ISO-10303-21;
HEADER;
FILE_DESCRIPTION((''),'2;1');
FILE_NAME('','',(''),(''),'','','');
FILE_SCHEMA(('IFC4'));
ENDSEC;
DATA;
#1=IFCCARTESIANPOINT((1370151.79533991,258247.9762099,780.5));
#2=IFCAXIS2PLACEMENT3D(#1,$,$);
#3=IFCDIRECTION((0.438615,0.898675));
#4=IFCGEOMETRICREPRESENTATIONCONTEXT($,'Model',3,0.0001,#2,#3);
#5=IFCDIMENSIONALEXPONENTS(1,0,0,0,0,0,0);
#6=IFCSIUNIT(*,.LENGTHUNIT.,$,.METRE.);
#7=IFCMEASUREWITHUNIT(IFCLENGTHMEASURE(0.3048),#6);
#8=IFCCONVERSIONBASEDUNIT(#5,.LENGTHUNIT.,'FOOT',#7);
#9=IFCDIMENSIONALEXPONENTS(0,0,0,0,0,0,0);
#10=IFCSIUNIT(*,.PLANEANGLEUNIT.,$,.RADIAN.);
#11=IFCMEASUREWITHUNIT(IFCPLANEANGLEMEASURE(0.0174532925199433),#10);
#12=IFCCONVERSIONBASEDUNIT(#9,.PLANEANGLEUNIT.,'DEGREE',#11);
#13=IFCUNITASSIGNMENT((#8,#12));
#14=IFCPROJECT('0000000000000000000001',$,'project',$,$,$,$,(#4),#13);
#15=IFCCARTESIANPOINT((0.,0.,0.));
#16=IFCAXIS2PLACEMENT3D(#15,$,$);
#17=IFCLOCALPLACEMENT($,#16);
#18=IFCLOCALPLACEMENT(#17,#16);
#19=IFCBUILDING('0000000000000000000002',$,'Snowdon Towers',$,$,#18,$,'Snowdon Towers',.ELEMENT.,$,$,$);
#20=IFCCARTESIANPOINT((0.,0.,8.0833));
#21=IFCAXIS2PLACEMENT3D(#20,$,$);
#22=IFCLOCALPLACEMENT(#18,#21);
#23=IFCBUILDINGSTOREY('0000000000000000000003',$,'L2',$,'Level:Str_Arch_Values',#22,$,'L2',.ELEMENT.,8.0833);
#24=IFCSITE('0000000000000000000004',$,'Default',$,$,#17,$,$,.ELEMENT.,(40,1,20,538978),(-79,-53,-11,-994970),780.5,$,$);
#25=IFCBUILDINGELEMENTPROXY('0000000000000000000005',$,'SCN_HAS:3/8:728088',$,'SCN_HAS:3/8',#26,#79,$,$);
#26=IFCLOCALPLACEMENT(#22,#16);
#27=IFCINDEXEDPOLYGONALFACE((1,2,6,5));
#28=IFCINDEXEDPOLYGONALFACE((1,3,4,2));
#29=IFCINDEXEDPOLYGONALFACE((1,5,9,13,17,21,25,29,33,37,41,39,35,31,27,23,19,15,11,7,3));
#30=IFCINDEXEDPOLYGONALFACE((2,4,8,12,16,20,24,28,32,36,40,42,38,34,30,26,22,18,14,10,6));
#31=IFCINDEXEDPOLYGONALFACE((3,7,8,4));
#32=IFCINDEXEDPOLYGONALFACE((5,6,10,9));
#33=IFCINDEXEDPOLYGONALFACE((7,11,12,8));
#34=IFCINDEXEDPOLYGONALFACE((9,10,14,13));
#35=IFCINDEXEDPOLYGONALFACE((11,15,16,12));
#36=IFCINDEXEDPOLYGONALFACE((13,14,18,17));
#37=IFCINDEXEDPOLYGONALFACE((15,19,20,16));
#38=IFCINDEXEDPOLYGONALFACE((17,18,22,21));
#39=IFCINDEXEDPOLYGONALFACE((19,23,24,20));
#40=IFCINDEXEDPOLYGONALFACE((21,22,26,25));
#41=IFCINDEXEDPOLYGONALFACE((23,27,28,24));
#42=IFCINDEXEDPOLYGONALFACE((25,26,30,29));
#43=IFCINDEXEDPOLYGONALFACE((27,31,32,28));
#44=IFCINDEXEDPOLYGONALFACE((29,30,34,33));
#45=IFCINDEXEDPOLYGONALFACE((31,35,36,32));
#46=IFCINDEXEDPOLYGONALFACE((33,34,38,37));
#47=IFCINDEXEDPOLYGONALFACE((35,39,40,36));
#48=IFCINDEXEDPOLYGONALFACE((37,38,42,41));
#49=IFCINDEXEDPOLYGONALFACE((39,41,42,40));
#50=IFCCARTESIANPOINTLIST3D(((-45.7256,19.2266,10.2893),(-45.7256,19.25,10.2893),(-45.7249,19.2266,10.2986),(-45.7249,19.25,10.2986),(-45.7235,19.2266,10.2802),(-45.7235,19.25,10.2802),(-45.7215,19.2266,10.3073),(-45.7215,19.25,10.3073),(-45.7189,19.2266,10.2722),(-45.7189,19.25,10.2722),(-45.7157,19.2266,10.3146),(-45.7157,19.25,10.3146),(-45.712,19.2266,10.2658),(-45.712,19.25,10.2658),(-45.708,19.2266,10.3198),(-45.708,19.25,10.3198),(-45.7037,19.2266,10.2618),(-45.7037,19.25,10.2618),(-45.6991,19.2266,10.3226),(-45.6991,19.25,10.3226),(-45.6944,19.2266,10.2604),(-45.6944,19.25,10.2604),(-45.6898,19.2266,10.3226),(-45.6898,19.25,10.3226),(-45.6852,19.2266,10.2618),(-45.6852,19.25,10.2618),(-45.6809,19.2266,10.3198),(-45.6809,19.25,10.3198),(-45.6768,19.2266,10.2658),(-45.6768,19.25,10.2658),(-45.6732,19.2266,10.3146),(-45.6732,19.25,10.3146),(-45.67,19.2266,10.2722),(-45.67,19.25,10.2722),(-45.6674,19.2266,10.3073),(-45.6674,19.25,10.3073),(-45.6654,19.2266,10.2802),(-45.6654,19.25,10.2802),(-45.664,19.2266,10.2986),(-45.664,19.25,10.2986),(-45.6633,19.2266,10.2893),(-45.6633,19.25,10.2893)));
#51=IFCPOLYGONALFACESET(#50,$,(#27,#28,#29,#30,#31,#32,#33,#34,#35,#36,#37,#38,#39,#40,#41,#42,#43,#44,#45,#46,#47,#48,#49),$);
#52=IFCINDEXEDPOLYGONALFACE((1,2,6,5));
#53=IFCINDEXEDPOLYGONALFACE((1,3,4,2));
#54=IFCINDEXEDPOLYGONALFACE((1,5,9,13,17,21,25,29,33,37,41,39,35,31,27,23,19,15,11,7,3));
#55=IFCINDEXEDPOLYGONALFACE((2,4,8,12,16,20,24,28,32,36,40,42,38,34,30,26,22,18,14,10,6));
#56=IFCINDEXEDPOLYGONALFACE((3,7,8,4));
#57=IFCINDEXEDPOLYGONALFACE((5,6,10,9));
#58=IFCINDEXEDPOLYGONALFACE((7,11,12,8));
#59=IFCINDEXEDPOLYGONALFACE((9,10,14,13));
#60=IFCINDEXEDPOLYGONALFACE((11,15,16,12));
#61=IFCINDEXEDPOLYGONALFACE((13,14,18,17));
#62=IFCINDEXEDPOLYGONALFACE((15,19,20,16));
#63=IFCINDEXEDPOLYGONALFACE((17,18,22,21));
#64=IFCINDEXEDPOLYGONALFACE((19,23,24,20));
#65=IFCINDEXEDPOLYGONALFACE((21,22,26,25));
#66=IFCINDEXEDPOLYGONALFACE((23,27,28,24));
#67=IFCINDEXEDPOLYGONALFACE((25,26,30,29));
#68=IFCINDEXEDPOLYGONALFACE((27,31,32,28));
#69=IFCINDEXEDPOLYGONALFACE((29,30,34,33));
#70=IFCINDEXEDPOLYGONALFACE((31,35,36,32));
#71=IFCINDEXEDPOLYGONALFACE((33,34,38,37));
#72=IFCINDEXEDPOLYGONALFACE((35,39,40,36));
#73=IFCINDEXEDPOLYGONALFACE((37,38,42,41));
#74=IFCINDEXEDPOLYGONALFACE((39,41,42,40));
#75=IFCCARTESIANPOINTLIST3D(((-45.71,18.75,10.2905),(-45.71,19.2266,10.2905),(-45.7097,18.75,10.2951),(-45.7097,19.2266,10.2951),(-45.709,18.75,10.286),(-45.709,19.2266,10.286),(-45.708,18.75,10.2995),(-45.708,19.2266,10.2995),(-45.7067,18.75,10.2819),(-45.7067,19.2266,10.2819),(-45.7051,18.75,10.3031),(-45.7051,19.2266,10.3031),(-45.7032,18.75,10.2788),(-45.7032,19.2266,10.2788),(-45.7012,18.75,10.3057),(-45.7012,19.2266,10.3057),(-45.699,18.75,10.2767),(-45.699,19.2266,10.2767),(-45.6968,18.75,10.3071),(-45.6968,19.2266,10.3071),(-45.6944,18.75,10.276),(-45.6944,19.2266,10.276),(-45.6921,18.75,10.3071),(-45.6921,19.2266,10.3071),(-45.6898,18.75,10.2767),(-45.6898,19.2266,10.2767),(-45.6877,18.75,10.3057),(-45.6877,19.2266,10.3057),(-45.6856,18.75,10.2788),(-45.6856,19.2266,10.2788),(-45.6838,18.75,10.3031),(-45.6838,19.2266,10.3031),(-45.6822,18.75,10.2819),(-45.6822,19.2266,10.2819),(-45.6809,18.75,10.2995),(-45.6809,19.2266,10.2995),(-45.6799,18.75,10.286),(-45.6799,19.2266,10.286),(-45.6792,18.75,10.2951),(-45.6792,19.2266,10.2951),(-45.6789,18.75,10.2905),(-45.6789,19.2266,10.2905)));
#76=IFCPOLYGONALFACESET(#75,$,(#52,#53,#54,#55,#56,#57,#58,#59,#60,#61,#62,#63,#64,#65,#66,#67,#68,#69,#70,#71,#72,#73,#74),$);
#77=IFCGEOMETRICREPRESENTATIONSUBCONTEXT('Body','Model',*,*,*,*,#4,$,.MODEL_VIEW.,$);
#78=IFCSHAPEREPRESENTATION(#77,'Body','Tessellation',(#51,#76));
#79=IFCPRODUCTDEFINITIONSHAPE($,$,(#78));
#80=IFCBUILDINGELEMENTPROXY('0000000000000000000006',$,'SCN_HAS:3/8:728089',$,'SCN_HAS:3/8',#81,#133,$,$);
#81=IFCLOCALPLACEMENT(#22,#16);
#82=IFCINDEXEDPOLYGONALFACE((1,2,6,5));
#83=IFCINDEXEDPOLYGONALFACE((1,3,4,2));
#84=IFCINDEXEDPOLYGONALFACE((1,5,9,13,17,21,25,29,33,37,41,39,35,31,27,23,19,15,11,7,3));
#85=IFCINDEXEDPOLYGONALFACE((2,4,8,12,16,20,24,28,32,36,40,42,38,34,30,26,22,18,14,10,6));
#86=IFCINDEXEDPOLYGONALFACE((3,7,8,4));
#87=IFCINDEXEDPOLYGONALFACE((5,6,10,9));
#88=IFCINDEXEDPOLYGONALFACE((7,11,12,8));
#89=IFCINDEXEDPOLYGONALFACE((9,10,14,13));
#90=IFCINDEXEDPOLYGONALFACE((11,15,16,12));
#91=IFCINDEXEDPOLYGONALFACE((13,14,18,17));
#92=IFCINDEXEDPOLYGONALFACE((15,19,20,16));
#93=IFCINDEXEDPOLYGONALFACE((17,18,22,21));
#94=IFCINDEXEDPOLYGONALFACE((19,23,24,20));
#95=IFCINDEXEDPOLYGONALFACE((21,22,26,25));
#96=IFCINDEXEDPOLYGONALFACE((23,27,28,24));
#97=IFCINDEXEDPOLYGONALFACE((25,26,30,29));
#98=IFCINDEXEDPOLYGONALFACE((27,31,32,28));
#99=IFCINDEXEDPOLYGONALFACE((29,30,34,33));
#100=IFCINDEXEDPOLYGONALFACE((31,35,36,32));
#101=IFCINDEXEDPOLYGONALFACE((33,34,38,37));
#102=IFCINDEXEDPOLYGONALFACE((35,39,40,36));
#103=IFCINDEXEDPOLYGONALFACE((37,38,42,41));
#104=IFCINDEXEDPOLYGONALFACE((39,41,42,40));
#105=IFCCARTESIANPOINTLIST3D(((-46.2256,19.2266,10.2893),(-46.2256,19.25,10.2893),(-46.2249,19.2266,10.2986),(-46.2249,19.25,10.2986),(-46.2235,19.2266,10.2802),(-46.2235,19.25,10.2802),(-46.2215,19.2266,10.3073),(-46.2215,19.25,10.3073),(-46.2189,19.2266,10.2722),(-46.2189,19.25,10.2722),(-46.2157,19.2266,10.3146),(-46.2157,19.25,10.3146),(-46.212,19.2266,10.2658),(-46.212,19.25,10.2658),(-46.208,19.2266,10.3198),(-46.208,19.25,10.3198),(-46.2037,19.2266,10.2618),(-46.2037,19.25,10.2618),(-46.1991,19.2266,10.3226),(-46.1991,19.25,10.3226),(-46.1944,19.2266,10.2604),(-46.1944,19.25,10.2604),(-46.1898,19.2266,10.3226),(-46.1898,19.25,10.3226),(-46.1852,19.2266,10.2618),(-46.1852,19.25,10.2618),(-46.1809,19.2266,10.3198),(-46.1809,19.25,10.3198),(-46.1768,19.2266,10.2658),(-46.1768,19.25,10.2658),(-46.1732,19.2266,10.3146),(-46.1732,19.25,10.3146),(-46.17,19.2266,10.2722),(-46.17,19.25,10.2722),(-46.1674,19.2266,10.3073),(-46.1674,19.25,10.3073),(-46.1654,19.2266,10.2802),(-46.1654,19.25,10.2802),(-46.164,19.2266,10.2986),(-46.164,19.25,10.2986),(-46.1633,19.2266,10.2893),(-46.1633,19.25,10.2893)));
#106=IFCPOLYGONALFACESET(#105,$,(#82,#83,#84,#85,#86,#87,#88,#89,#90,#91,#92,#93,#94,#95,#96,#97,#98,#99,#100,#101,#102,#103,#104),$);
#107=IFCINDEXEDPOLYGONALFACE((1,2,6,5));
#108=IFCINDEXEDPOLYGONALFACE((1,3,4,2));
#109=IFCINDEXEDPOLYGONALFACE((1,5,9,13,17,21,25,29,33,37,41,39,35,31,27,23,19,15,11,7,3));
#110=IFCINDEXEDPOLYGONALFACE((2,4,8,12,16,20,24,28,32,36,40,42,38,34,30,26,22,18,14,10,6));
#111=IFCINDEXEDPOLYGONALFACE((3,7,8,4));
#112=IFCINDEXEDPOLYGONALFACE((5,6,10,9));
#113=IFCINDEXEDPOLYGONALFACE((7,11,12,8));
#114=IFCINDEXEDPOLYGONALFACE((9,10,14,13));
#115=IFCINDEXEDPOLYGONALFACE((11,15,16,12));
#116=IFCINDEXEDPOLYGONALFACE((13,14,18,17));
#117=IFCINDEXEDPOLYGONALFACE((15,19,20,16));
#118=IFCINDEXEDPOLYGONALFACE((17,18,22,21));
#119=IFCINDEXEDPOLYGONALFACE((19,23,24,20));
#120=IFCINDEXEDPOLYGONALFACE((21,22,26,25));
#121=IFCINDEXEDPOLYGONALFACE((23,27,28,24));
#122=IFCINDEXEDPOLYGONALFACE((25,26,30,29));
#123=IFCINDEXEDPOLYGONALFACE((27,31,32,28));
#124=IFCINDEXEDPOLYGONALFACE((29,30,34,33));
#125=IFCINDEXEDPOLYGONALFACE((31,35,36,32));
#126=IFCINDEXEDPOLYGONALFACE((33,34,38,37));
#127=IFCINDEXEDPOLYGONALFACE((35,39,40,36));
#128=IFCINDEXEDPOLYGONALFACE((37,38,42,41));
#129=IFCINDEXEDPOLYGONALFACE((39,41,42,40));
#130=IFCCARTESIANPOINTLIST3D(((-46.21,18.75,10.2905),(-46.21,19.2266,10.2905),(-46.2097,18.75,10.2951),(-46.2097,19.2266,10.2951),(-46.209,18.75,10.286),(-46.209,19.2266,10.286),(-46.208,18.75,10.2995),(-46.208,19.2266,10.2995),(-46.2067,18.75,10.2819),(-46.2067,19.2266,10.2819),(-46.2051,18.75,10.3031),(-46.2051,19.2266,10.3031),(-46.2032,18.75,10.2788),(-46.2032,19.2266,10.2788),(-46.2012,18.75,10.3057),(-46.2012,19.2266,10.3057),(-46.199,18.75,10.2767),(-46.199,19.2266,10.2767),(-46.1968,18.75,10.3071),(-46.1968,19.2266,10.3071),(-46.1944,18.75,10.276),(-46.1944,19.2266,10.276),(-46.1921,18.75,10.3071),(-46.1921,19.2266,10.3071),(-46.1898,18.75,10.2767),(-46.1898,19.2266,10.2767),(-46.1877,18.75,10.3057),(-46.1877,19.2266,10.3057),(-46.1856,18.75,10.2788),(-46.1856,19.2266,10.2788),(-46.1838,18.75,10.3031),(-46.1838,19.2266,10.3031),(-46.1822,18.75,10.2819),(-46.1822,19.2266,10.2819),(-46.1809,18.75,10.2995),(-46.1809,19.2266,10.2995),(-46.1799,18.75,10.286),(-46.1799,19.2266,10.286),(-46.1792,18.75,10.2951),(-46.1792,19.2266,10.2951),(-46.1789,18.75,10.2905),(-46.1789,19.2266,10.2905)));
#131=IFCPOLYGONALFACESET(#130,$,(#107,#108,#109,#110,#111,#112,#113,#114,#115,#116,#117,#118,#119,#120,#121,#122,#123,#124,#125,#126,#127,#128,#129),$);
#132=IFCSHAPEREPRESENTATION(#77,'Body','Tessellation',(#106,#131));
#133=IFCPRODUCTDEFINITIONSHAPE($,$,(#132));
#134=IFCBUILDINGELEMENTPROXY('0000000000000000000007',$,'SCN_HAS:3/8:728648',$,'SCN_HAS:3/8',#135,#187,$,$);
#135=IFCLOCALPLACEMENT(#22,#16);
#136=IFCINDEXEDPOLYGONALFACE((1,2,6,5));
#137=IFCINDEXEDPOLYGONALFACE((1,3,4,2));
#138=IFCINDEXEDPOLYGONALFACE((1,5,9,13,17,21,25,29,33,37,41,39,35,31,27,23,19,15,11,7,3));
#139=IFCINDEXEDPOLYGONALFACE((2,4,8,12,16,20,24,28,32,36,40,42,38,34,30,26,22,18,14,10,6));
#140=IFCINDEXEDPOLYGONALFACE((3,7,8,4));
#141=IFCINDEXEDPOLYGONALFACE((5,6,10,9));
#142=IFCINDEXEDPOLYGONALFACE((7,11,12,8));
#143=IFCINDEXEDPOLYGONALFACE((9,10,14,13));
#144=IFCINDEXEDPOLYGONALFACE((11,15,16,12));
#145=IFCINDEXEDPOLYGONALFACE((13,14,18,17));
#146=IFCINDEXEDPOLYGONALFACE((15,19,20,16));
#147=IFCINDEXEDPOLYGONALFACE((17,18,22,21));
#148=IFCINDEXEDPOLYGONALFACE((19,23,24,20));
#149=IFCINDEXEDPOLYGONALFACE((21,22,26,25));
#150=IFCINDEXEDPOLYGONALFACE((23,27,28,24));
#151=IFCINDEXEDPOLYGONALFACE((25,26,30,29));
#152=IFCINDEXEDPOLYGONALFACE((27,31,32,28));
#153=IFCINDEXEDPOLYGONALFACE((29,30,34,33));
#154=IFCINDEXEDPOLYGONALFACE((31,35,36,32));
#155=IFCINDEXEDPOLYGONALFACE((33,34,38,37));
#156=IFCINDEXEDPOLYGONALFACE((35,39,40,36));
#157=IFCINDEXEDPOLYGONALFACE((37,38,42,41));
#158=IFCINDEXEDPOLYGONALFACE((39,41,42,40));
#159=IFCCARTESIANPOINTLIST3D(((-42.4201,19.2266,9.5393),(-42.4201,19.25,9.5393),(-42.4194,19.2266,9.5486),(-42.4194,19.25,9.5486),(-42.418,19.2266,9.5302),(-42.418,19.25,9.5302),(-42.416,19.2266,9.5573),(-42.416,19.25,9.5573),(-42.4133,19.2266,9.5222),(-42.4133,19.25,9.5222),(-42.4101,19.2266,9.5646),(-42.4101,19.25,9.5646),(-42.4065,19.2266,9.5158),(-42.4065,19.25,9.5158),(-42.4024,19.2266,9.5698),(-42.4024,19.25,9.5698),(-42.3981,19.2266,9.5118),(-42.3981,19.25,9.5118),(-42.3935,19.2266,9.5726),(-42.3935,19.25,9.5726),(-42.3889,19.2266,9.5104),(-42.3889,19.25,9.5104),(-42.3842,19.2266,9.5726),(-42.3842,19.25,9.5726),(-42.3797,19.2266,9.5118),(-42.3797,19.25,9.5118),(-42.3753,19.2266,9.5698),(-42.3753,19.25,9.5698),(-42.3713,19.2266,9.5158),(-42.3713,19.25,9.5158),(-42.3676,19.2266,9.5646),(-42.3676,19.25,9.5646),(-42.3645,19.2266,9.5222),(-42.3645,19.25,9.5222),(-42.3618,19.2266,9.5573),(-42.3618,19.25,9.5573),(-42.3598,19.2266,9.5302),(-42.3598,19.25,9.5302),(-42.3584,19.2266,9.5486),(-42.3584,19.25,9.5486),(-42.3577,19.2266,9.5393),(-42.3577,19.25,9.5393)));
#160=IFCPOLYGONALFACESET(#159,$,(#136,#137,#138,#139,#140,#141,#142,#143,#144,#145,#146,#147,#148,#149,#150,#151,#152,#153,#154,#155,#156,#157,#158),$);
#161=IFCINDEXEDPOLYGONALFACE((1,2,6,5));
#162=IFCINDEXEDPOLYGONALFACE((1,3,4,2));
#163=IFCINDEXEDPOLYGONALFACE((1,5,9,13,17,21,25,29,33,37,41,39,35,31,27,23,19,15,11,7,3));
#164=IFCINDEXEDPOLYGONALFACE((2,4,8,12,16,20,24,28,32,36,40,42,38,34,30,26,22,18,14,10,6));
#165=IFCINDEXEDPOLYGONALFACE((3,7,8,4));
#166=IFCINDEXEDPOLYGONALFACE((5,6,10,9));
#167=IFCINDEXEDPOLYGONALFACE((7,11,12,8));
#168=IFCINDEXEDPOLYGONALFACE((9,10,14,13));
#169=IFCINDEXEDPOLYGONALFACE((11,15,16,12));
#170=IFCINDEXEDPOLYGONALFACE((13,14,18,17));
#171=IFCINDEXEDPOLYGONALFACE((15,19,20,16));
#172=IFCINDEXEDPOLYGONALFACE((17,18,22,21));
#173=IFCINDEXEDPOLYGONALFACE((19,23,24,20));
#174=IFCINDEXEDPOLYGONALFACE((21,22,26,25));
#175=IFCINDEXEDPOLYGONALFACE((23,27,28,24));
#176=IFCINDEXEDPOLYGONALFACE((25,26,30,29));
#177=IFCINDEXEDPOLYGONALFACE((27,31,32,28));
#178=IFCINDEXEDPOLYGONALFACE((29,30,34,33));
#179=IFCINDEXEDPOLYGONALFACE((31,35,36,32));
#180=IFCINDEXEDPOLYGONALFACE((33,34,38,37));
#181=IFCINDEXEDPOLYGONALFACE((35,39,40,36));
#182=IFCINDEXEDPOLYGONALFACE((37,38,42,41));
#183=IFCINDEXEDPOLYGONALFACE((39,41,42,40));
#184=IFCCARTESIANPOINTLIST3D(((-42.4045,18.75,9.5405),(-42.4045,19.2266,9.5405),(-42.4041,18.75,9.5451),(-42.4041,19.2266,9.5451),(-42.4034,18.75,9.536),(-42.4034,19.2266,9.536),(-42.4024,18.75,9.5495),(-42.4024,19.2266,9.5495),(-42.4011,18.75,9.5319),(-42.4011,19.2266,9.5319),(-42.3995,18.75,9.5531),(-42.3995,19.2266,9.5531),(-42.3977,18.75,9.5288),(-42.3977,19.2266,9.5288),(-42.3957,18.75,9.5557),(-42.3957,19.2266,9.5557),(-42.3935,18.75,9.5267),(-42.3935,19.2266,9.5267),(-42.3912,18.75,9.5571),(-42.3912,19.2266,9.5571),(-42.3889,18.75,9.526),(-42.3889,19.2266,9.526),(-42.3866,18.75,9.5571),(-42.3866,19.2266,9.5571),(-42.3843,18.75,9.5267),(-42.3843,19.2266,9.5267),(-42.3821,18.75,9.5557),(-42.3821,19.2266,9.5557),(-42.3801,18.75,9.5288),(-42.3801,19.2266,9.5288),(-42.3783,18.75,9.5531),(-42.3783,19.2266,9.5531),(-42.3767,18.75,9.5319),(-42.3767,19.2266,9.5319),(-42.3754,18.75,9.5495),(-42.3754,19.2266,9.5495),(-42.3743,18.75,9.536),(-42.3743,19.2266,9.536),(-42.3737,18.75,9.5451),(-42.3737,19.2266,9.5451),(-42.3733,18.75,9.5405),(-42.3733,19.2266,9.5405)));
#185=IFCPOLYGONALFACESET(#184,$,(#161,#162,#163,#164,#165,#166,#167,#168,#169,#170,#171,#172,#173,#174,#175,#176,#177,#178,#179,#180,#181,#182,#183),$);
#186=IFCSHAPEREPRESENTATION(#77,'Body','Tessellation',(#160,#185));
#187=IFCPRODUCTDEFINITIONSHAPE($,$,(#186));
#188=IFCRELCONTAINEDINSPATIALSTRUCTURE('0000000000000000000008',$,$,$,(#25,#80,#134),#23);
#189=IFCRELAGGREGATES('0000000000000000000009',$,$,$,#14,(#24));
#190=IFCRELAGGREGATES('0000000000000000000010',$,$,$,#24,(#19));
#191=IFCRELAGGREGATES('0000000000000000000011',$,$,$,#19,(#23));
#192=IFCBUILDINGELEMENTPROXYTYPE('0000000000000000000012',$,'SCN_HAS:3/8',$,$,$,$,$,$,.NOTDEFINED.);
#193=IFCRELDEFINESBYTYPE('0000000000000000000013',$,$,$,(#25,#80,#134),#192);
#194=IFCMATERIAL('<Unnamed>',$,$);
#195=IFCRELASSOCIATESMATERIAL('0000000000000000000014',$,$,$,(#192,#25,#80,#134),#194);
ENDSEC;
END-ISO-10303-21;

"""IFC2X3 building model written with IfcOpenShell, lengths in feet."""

from ifc_helpers import new_model, entity, si_unit, converted_unit, direction, frame, frame_2d, origin, place, context, subcontext, project, spatial, circle, extrude, source, transform, mapped, material, type_object, type_shapes, element, save


model = new_model("IFC2X3")

# Units and contexts
model_context = context("Model", 3, precision=0.0001, world=frame((1370151.79533991, 258247.9762099, 780.5)), true_north=direction((0.438615, 0.898675)))
body_context = subcontext(model_context, "Body", "Model", "MODEL_VIEW")
ifc_project = project(units=[converted_unit("LENGTHUNIT", "FOOT", entity("IfcLengthMeasure", 0.3048), si_unit("LENGTHUNIT", "METRE"), dimensions=[1, 0, 0, 0, 0, 0, 0]), converted_unit("PLANEANGLEUNIT", "DEGREE", entity("IfcPlaneAngleMeasure", 0.0174532925199433), si_unit("PLANEANGLEUNIT", "RADIAN"), dimensions=[0, 0, 0, 0, 0, 0, 0])], contexts=[model_context])

# Site, building, storey
site_placement = place(None, origin())
site = spatial("IfcSite", under=ifc_project, at=site_placement, Name="Default", CompositionType="ELEMENT", RefLatitude=(40, 1, 20, 538978), RefLongitude=(-79, -53, -11, -994970), RefElevation=780.5)
building_placement = place(site_placement, origin())
building = spatial("IfcBuilding", under=site, at=building_placement, Name="Snowdon Towers", LongName="Snowdon Towers", CompositionType="ELEMENT")
storey_placement = place(building_placement, frame((0.0, 0.0, 8.0833)))
storey = spatial("IfcBuildingStorey", under=building, at=storey_placement, Name="L2", ObjectType="Level:Str_Arch_Values", LongName="L2", CompositionType="ELEMENT", Elevation=8.0833)

# Building element proxies
ifc_material_1 = material(Name="<Unnamed>")
building_element_proxy_type_1 = type_object("IfcBuildingElementProxyType", Name="SCN_HAS:3/8", PredefinedType="NOTDEFINED", material=ifc_material_1)
shared_shape_1 = source(origin(), body_context, "Body", "SweptSolid", [
    extrude(circle(Radius=0.0312, at=frame_2d((0.0, 0.0), x_axis=(1.0, 0.0))), frame((0.0, 0.0, -0.5), z_axis=(0.0, 0.0, 1.0), x_axis=(0.0, -1.0, 0.0)), (0.0, 0.0, 1.0), 0.0234),
    extrude(circle(Radius=0.0156, at=frame_2d((0.0, 0.0), x_axis=(1.0, 0.0))), frame((0.0, 0.0, -0.4766), z_axis=(0.0, 0.0, 1.0), x_axis=(0.0, -1.0, 0.0)), (0.0, 0.0, 1.0), 0.4766),
])
type_shapes(building_element_proxy_type_1, [shared_shape_1])
for number, where, z_axis, x_axis, name in (
    (1, (-45.6944, 18.75, 10.2917), (0.0, -1.0, 0.0), (1.0, 0.0, 0.0), "SCN_HAS:3/8:728088"),
    (2, (-46.1944, 18.75, 10.2917), (0.0, -1.0, 0.0), (1.0, 0.0, 0.0), "SCN_HAS:3/8:728089"),
    (3, (-42.3889, 18.75, 9.5417), (0.0, -1.0, 0.0), (1.0, 0.0, 0.0), "SCN_HAS:3/8:728648"),
):
    element("IfcBuildingElementProxy", number, at=place(storey_placement, frame(where, z_axis=z_axis, x_axis=x_axis)), inside=storey, type_object=building_element_proxy_type_1, material=ifc_material_1, Name=name, ObjectType="SCN_HAS:3/8", context=body_context, shape_type="MappedRepresentation", body=[
        mapped(shared_shape_1, transform((0.0, 0.0, 0.0), scale=1.0)),
    ])

save(model, "model.ifc")
